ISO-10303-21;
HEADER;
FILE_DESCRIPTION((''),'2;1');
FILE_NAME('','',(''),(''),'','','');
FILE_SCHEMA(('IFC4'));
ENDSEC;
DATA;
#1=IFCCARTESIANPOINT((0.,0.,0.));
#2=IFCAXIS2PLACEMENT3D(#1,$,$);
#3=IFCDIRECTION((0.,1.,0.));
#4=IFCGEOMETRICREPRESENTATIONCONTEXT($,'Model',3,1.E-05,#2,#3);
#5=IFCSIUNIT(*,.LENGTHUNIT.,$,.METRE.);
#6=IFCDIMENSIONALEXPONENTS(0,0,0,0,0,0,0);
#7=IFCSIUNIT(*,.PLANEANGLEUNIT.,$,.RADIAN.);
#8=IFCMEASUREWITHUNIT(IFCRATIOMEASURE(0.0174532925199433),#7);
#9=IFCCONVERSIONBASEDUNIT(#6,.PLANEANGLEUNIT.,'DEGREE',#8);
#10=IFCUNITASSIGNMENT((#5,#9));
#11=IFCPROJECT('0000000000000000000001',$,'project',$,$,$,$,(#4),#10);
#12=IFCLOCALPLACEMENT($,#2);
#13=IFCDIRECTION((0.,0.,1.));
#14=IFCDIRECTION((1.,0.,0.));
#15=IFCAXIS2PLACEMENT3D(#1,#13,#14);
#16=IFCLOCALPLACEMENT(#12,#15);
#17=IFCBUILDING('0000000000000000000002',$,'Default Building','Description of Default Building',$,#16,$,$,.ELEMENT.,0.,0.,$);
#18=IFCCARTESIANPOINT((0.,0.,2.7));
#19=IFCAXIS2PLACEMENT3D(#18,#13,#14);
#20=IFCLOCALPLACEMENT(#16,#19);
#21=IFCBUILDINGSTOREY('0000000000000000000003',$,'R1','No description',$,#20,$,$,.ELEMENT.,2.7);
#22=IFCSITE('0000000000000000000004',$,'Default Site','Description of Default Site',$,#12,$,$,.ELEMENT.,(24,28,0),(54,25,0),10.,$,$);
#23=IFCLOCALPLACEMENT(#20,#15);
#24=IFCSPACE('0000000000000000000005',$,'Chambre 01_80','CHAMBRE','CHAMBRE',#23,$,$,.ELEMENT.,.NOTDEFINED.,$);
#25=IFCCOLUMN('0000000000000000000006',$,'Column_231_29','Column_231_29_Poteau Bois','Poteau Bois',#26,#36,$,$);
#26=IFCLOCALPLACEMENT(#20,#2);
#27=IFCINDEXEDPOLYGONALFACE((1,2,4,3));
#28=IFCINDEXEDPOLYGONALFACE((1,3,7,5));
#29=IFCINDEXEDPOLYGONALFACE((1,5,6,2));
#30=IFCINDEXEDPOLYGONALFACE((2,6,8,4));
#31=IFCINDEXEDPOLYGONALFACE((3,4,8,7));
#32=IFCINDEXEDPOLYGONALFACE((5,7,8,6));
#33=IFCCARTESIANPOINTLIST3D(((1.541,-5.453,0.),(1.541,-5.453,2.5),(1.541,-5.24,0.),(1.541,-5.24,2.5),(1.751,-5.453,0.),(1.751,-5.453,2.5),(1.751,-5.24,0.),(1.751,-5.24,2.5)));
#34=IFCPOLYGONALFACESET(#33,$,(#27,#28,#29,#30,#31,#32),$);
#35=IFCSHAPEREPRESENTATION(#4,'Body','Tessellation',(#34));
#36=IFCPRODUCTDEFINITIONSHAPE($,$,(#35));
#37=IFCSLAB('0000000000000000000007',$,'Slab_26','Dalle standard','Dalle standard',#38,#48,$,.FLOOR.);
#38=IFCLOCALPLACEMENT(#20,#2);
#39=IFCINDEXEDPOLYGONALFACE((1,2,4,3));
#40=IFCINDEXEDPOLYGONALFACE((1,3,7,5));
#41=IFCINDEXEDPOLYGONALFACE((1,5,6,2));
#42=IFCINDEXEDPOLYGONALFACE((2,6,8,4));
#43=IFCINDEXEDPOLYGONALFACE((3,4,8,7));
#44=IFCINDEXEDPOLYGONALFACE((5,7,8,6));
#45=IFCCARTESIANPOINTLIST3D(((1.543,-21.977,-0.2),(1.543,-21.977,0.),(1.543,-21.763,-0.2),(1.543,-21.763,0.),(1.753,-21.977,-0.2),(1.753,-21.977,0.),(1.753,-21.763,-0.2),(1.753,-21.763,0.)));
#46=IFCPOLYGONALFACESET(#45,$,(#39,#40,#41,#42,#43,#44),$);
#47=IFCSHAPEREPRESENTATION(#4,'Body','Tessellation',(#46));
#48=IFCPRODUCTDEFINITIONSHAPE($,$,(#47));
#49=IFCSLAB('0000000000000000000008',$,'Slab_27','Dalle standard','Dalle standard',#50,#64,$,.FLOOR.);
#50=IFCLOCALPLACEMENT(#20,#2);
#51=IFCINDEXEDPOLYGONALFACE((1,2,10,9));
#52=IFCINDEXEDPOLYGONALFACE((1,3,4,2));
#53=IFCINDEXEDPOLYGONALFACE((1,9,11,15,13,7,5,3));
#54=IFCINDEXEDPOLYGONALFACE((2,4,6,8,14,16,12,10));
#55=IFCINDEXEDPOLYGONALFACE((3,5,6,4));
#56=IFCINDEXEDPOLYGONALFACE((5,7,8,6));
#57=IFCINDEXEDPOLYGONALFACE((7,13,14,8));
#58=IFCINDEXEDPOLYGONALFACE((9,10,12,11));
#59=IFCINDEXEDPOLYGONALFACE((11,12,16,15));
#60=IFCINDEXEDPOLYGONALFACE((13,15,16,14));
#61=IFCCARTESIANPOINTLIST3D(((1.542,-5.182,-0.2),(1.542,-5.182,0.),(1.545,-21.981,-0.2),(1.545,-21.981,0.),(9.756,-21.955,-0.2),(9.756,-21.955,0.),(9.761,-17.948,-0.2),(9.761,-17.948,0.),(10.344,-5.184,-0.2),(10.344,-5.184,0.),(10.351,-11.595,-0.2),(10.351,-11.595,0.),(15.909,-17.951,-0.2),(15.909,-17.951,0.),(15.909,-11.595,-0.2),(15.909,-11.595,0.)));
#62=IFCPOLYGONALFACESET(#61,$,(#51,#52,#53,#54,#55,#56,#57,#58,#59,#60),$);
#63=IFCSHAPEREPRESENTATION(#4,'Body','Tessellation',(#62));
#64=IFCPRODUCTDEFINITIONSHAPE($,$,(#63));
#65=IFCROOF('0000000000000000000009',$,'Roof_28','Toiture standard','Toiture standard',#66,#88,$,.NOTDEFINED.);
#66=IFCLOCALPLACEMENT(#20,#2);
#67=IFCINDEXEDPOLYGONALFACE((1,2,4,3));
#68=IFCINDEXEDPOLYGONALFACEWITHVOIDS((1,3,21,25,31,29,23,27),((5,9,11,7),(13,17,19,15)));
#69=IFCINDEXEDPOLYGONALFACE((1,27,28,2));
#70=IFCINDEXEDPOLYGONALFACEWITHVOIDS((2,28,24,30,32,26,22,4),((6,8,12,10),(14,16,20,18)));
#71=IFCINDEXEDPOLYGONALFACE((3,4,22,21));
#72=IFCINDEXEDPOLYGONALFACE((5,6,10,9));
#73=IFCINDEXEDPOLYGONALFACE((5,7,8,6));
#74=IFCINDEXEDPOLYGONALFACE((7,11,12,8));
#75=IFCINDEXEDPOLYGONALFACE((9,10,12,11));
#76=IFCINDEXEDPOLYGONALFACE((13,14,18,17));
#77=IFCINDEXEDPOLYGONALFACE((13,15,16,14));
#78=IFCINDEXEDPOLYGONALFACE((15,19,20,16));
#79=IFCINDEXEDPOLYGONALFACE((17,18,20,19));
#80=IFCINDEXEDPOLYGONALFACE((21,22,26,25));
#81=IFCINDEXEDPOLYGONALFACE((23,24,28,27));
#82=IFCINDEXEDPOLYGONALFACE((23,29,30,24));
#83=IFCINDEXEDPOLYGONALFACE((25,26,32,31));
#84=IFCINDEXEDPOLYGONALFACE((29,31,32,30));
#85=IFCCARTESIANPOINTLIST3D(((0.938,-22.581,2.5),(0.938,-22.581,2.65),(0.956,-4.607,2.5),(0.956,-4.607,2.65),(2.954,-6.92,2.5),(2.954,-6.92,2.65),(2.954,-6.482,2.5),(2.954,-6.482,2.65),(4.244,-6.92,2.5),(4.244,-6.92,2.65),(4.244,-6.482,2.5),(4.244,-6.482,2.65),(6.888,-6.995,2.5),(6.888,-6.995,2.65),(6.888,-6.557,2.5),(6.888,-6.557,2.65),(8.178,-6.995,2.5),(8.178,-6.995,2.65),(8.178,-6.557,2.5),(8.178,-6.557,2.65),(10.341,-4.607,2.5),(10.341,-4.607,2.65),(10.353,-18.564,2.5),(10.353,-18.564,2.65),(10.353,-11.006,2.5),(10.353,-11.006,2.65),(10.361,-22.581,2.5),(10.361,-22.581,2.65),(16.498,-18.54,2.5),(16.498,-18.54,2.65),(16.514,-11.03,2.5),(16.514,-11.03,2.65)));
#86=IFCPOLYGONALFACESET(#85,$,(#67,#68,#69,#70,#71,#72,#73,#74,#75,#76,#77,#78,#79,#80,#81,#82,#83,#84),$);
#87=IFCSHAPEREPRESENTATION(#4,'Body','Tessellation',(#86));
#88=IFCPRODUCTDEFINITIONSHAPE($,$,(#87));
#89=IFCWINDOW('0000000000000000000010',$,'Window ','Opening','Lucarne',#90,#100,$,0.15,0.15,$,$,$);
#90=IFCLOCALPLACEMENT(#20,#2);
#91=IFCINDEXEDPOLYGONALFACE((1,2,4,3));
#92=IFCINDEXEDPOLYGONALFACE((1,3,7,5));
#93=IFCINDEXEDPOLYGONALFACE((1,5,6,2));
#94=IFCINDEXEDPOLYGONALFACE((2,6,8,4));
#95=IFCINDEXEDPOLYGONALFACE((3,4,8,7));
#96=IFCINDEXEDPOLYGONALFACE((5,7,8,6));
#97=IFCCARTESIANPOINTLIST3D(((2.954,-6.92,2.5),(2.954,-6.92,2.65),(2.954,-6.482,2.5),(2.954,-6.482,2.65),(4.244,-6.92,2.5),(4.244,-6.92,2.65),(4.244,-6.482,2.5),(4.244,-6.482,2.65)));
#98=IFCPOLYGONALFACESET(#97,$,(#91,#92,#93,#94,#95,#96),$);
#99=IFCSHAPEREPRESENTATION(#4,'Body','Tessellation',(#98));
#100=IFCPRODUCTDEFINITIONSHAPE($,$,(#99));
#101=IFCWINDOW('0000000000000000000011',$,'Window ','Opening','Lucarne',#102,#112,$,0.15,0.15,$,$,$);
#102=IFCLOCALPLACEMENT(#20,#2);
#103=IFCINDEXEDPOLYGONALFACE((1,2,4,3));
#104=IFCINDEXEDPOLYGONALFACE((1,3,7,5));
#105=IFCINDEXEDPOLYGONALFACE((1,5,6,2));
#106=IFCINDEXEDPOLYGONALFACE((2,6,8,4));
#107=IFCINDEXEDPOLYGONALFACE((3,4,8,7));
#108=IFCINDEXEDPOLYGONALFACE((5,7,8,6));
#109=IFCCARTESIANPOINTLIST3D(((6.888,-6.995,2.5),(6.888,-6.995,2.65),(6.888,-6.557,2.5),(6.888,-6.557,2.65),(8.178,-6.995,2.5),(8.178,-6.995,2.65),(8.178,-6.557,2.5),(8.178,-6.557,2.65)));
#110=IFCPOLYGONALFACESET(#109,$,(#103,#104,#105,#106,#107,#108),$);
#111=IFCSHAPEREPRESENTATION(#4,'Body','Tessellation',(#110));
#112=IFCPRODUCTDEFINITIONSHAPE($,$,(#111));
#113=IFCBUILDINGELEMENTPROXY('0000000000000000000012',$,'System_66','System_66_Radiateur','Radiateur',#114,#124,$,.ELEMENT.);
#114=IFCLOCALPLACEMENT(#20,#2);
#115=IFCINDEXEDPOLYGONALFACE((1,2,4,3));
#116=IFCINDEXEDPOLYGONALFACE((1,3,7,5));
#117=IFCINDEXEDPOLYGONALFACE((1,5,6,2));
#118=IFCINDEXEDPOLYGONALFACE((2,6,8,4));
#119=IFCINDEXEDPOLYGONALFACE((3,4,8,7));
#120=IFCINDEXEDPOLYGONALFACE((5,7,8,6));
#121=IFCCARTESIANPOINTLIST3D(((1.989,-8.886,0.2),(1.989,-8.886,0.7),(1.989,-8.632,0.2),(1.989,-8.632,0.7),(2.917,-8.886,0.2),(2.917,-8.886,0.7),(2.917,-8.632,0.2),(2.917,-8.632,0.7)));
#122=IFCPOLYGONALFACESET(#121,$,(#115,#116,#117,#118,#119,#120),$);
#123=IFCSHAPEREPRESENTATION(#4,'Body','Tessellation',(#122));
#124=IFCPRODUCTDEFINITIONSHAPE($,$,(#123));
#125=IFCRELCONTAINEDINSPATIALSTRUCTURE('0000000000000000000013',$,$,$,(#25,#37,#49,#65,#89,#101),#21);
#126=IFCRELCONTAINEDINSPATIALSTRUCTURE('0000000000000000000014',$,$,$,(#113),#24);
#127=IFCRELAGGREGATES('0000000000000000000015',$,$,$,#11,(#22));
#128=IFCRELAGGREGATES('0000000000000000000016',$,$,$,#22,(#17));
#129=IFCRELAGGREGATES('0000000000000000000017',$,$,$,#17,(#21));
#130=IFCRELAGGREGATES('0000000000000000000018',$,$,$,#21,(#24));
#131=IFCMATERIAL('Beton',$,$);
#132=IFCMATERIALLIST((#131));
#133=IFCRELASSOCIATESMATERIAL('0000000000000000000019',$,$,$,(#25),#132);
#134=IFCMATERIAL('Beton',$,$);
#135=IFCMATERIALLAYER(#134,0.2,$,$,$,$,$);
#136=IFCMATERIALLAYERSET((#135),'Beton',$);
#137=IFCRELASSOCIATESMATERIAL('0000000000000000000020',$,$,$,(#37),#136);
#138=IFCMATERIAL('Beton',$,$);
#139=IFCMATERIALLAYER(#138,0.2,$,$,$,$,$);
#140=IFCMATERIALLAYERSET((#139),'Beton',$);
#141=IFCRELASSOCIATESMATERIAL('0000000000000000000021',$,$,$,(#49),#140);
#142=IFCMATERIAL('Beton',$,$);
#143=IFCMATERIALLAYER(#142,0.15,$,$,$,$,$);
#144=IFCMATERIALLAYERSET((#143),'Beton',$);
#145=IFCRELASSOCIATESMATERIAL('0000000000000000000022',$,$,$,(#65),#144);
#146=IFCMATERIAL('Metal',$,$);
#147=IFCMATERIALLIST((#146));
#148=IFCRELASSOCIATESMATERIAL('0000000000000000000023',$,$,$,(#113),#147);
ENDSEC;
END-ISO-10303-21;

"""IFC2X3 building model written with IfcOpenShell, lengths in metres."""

from ifc_helpers import new_model, entity, si_unit, converted_unit, direction, frame, origin, origin_with_axes, place, context, project, spatial, polyline, outline, extrude, material, material_list, layer, layer_set, layer_usage, element, fill, save


model = new_model("IFC2X3")

# Units and contexts
model_context = context("Model", 3, precision=1e-05, world=origin(), true_north=direction((0.0, 1.0, 0.0)))
ifc_project = project(units=[si_unit("LENGTHUNIT", "METRE"), converted_unit("PLANEANGLEUNIT", "DEGREE", entity("IfcRatioMeasure", 0.0174532925199433), si_unit("PLANEANGLEUNIT", "RADIAN"), dimensions=[0, 0, 0, 0, 0, 0, 0])], contexts=[model_context])

# Site, building, storey
site_placement = place(None, origin())
site = spatial("IfcSite", under=ifc_project, at=site_placement, Name="Default Site", Description="Description of Default Site", CompositionType="ELEMENT", RefLatitude=(24, 28, 0), RefLongitude=(54, 25, 0), RefElevation=10.0)
building_placement = place(site_placement, origin_with_axes())
building = spatial("IfcBuilding", under=site, at=building_placement, Name="Default Building", Description="Description of Default Building", CompositionType="ELEMENT", ElevationOfRefHeight=0.0, ElevationOfTerrain=0.0)
storey_placement = place(building_placement, frame((0.0, 0.0, 2.7), z_axis=(0.0, 0.0, 1.0), x_axis=(1.0, 0.0, 0.0)))
storey = spatial("IfcBuildingStorey", under=building, at=storey_placement, Name="R1", Description="No description", CompositionType="ELEMENT", Elevation=2.7)

# Column
ifc_material_1 = material(Name="Beton")
ifc_material_list_1 = material_list([ifc_material_1])
column_placement = place(storey_placement, frame((1.646, -5.24, 0.0), z_axis=(0.0, 0.0, 1.0), x_axis=(0.0, -0.213, 0.0)))
element("IfcColumn", 1, at=column_placement, inside=storey, material=ifc_material_list_1, Name="Column_231_29", Description="Column_231_29_Poteau Bois", ObjectType="Poteau Bois", context=model_context, shape_type="SweptSolid", body=[
    extrude(outline(polyline([(0.0, -0.105), (0.213, -0.105), (0.213, 0.105), (0.0, 0.105), (0.0, -0.105)])), origin(), (0.0, 0.0, 1.0), 2.5),
])

# Slabs
ifc_material_2 = material(Name="Beton")
ifc_layer_1 = layer(ifc_material_2, 0.2)
ifc_layer_set_1 = layer_set([ifc_layer_1], Name="Beton")
ifc_layer_usage_1 = layer_usage(ifc_layer_set_1, "AXIS3", "POSITIVE", 0.2)
slab_1_placement = place(storey_placement, frame((0.0, 0.0, -0.2), z_axis=(0.0, 0.0, 1.0), x_axis=(1.0, 0.0, 0.0)))
element("IfcSlab", 2, at=slab_1_placement, inside=storey, material=ifc_layer_usage_1, Name="Slab_26", Description="Dalle standard", ObjectType="Dalle standard", PredefinedType="FLOOR", context=model_context, shape_type="SweptSolid", body=[
    extrude(outline(polyline([(1.543, -21.763), (1.543, -21.977), (1.753, -21.977), (1.753, -21.763), (1.543, -21.763)])), origin(), (0.0, 0.0, 1.0), 0.2),
])
ifc_material_3 = material(Name="Beton")
ifc_layer_2 = layer(ifc_material_3, 0.2)
ifc_layer_set_2 = layer_set([ifc_layer_2], Name="Beton")
ifc_layer_usage_2 = layer_usage(ifc_layer_set_2, "AXIS3", "POSITIVE", 0.2)
slab_2_placement = place(storey_placement, frame((0.0, 0.0, -0.2), z_axis=(0.0, 0.0, 1.0), x_axis=(1.0, 0.0, 0.0)))
element("IfcSlab", 3, at=slab_2_placement, inside=storey, material=ifc_layer_usage_2, Name="Slab_27", Description="Dalle standard", ObjectType="Dalle standard", PredefinedType="FLOOR", context=model_context, shape_type="SweptSolid", body=[
    extrude(outline(polyline([(10.344, -5.184), (10.351, -11.595), (15.909, -11.595), (15.909, -17.951), (9.761, -17.948), (9.756, -21.955), (1.545, -21.981), (1.542, -5.182), (10.344, -5.184)])), origin(), (0.0, 0.0, 1.0), 0.2),
])

# Shared definitions
space_1_placement = place(storey_placement, origin_with_axes())
space_1 = spatial("IfcSpace", under=storey, at=space_1_placement, Name="Chambre 01_80", Description="CHAMBRE", ObjectType="CHAMBRE", CompositionType="ELEMENT", InteriorOrExteriorSpace="NOTDEFINED")

# Roof, openings, windows
ifc_material_4 = material(Name="Beton")
ifc_layer_3 = layer(ifc_material_4, 0.15)
ifc_layer_set_3 = layer_set([ifc_layer_3], Name="Beton")
ifc_layer_usage_3 = layer_usage(ifc_layer_set_3, "AXIS3", "POSITIVE", 0.15)
roof_placement = place(storey_placement, frame((0.0, 0.0, 2.5), z_axis=(0.0, 0.0, 1.0), x_axis=(1.0, 0.0, 0.0)))
roof = element("IfcRoof", 4, at=roof_placement, inside=storey, material=ifc_layer_usage_3, Name="Roof_28", Description="Toiture standard", ObjectType="Toiture standard", ShapeType="NOTDEFINED", context=model_context, shape_type="SweptSolid", body=[
    extrude(outline(polyline([(0.956, -4.607), (10.341, -4.607), (10.353, -11.006), (16.514, -11.03), (16.498, -18.54), (10.353, -18.564), (10.361, -22.581), (0.938, -22.581), (0.956, -4.607)])), origin(), (0.0, 0.0, 1.0), 0.15),
])
opening_1_placement = place(storey_placement, frame((0.0, 0.0, 2.5), z_axis=(0.0, 0.0, 1.0), x_axis=(1.0, 0.0, 0.0)))
opening_1 = element("IfcOpeningElement", 5, at=opening_1_placement, inside=storey, cuts=roof, ObjectType="Vitre", context=model_context, shape_type="SweptSolid", body=[
    extrude(outline(polyline([(2.954, -6.92), (4.244, -6.92), (4.244, -6.482), (2.954, -6.482), (2.954, -6.92)])), origin(), (0.0, 0.0, 1.0), 0.15),
])
opening_2_placement = place(storey_placement, frame((0.0, 0.0, 2.5), z_axis=(0.0, 0.0, 1.0), x_axis=(1.0, 0.0, 0.0)))
opening_2 = element("IfcOpeningElement", 6, at=opening_2_placement, inside=storey, cuts=roof, ObjectType="Vitre", context=model_context, shape_type="SweptSolid", body=[
    extrude(outline(polyline([(6.888, -6.995), (8.178, -6.995), (8.178, -6.557), (6.888, -6.557), (6.888, -6.995)])), origin(), (0.0, 0.0, 1.0), 0.15),
])
window_1_placement = place(storey_placement, frame((0.0, 0.0, 2.5), z_axis=(0.0, 0.0, 1.0), x_axis=(1.0, 0.0, 0.0)))
window_1 = element("IfcWindow", 7, at=window_1_placement, inside=storey, Name="Window ", Description="Opening", ObjectType="Lucarne", OverallHeight=0.15, OverallWidth=0.15, context=model_context, shape_type="SweptSolid", body=[
    extrude(outline(polyline([(2.954, -6.92), (4.244, -6.92), (4.244, -6.482), (2.954, -6.482), (2.954, -6.92)])), origin(), (0.0, 0.0, 1.0), 0.15),
])
fill(opening_1, window_1)
window_2_placement = place(storey_placement, frame((0.0, 0.0, 2.5), z_axis=(0.0, 0.0, 1.0), x_axis=(1.0, 0.0, 0.0)))
window_2 = element("IfcWindow", 8, at=window_2_placement, inside=storey, Name="Window ", Description="Opening", ObjectType="Lucarne", OverallHeight=0.15, OverallWidth=0.15, context=model_context, shape_type="SweptSolid", body=[
    extrude(outline(polyline([(6.888, -6.995), (8.178, -6.995), (8.178, -6.557), (6.888, -6.557), (6.888, -6.995)])), origin(), (0.0, 0.0, 1.0), 0.15),
])
fill(opening_2, window_2)

# Shared definitions
ifc_material_5 = material(Name="Metal")
ifc_material_list_2 = material_list([ifc_material_5])

# Building element proxy
proxy_placement = place(storey_placement, frame((1.989, -8.759, 0.2), z_axis=(0.0, 0.0, 1.0), x_axis=(0.928, 0.0, 0.0)))
element("IfcBuildingElementProxy", 9, at=proxy_placement, inside=space_1, material=ifc_material_list_2, Name="System_66", Description="System_66_Radiateur", ObjectType="Radiateur", CompositionType="ELEMENT", context=model_context, shape_type="SweptSolid", body=[
    extrude(outline(polyline([(0.0, -0.127), (0.928, -0.127), (0.928, 0.127), (0.0, 0.127), (0.0, -0.127)])), origin(), (0.0, 0.0, 1.0), 0.5),
])

save(model, "model.ifc")
